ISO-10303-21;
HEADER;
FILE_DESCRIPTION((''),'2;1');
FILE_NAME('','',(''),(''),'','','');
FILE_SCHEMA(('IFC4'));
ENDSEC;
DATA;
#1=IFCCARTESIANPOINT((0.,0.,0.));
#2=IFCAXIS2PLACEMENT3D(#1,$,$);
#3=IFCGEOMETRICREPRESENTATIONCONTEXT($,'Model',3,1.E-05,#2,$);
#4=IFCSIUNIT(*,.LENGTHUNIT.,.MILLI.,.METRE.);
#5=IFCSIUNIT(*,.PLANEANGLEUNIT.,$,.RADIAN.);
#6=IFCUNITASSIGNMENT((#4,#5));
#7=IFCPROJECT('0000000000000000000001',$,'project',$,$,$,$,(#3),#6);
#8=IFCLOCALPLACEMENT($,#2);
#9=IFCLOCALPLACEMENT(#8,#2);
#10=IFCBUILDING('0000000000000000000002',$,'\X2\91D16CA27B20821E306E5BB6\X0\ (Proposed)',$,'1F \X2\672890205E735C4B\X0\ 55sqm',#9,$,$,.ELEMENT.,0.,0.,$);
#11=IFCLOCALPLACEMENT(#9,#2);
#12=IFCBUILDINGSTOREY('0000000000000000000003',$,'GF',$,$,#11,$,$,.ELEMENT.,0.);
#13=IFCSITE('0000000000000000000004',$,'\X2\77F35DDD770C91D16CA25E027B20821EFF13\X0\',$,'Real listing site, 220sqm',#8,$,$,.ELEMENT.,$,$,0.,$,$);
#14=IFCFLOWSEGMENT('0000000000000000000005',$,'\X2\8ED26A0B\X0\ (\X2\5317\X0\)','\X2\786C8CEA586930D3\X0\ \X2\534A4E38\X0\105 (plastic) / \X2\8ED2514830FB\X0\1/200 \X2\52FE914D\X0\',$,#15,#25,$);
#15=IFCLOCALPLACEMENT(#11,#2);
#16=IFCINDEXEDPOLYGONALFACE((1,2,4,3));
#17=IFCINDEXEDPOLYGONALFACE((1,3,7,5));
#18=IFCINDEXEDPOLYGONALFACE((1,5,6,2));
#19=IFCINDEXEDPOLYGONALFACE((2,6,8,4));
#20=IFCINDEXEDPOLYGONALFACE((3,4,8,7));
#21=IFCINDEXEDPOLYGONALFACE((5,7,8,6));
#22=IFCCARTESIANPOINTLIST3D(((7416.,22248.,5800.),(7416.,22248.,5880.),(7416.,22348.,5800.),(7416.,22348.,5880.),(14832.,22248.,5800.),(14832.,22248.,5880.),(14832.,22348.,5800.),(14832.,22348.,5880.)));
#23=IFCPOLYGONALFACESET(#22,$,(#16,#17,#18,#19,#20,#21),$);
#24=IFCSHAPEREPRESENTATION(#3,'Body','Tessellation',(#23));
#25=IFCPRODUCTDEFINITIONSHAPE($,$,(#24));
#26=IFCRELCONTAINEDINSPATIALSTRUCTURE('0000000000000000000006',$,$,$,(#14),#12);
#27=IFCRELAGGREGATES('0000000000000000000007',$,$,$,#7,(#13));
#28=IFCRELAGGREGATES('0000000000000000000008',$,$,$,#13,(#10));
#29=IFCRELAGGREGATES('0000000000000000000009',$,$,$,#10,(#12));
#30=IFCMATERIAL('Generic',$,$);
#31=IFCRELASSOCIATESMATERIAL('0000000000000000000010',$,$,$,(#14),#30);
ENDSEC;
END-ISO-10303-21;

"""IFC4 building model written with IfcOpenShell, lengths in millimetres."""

from ifc_helpers import new_model, si_unit, frame, frame_2d, origin, place, context, project, spatial, rectangle, extrude, material, element, save


model = new_model("IFC4")

# Units and contexts
model_context = context("Model", 3, precision=1e-05, world=origin())
ifc_project = project(units=[si_unit("LENGTHUNIT", "METRE", prefix="MILLI"), si_unit("PLANEANGLEUNIT", "RADIAN")], contexts=[model_context])

# Site, building, storey
site_placement = place(None, origin())
site = spatial("IfcSite", under=ifc_project, at=site_placement, Name="石川県金沢市笠舞３", ObjectType="Real listing site, 220sqm", CompositionType="ELEMENT", RefElevation=0.0)
building_placement = place(site_placement, origin())
building = spatial("IfcBuilding", under=site, at=building_placement, Name="金沢笠舞の家 (Proposed)", ObjectType="1F 木造平屋 55sqm", CompositionType="ELEMENT", ElevationOfRefHeight=0.0, ElevationOfTerrain=0.0)
storey_placement = place(building_placement, origin())
storey = spatial("IfcBuildingStorey", under=building, at=storey_placement, Name="GF", CompositionType="ELEMENT", Elevation=0.0)

# Shared definitions
ifc_material_1 = material(Name="Generic")

# Flow segment
flow_segment_1_placement = place(storey_placement, frame((3708.0, 11124.0, 2900.0)))
element("IfcFlowSegment", 1, at=flow_segment_1_placement, inside=storey, material=ifc_material_1, Name="軒樋 (北)", Description="硬質塩ビ 半丸105 (plastic) / 軒先・1/200 勾配", context=model_context, shape_type="SweptSolid", body=[
    extrude(rectangle(XDim=7416.0, YDim=100.0, at=frame_2d((3708.0, 50.0))), frame((3708.0, 11124.0, 2900.0)), (0.0, 0.0, 1.0), 80.0),
])

save(model, "model.ifc")
